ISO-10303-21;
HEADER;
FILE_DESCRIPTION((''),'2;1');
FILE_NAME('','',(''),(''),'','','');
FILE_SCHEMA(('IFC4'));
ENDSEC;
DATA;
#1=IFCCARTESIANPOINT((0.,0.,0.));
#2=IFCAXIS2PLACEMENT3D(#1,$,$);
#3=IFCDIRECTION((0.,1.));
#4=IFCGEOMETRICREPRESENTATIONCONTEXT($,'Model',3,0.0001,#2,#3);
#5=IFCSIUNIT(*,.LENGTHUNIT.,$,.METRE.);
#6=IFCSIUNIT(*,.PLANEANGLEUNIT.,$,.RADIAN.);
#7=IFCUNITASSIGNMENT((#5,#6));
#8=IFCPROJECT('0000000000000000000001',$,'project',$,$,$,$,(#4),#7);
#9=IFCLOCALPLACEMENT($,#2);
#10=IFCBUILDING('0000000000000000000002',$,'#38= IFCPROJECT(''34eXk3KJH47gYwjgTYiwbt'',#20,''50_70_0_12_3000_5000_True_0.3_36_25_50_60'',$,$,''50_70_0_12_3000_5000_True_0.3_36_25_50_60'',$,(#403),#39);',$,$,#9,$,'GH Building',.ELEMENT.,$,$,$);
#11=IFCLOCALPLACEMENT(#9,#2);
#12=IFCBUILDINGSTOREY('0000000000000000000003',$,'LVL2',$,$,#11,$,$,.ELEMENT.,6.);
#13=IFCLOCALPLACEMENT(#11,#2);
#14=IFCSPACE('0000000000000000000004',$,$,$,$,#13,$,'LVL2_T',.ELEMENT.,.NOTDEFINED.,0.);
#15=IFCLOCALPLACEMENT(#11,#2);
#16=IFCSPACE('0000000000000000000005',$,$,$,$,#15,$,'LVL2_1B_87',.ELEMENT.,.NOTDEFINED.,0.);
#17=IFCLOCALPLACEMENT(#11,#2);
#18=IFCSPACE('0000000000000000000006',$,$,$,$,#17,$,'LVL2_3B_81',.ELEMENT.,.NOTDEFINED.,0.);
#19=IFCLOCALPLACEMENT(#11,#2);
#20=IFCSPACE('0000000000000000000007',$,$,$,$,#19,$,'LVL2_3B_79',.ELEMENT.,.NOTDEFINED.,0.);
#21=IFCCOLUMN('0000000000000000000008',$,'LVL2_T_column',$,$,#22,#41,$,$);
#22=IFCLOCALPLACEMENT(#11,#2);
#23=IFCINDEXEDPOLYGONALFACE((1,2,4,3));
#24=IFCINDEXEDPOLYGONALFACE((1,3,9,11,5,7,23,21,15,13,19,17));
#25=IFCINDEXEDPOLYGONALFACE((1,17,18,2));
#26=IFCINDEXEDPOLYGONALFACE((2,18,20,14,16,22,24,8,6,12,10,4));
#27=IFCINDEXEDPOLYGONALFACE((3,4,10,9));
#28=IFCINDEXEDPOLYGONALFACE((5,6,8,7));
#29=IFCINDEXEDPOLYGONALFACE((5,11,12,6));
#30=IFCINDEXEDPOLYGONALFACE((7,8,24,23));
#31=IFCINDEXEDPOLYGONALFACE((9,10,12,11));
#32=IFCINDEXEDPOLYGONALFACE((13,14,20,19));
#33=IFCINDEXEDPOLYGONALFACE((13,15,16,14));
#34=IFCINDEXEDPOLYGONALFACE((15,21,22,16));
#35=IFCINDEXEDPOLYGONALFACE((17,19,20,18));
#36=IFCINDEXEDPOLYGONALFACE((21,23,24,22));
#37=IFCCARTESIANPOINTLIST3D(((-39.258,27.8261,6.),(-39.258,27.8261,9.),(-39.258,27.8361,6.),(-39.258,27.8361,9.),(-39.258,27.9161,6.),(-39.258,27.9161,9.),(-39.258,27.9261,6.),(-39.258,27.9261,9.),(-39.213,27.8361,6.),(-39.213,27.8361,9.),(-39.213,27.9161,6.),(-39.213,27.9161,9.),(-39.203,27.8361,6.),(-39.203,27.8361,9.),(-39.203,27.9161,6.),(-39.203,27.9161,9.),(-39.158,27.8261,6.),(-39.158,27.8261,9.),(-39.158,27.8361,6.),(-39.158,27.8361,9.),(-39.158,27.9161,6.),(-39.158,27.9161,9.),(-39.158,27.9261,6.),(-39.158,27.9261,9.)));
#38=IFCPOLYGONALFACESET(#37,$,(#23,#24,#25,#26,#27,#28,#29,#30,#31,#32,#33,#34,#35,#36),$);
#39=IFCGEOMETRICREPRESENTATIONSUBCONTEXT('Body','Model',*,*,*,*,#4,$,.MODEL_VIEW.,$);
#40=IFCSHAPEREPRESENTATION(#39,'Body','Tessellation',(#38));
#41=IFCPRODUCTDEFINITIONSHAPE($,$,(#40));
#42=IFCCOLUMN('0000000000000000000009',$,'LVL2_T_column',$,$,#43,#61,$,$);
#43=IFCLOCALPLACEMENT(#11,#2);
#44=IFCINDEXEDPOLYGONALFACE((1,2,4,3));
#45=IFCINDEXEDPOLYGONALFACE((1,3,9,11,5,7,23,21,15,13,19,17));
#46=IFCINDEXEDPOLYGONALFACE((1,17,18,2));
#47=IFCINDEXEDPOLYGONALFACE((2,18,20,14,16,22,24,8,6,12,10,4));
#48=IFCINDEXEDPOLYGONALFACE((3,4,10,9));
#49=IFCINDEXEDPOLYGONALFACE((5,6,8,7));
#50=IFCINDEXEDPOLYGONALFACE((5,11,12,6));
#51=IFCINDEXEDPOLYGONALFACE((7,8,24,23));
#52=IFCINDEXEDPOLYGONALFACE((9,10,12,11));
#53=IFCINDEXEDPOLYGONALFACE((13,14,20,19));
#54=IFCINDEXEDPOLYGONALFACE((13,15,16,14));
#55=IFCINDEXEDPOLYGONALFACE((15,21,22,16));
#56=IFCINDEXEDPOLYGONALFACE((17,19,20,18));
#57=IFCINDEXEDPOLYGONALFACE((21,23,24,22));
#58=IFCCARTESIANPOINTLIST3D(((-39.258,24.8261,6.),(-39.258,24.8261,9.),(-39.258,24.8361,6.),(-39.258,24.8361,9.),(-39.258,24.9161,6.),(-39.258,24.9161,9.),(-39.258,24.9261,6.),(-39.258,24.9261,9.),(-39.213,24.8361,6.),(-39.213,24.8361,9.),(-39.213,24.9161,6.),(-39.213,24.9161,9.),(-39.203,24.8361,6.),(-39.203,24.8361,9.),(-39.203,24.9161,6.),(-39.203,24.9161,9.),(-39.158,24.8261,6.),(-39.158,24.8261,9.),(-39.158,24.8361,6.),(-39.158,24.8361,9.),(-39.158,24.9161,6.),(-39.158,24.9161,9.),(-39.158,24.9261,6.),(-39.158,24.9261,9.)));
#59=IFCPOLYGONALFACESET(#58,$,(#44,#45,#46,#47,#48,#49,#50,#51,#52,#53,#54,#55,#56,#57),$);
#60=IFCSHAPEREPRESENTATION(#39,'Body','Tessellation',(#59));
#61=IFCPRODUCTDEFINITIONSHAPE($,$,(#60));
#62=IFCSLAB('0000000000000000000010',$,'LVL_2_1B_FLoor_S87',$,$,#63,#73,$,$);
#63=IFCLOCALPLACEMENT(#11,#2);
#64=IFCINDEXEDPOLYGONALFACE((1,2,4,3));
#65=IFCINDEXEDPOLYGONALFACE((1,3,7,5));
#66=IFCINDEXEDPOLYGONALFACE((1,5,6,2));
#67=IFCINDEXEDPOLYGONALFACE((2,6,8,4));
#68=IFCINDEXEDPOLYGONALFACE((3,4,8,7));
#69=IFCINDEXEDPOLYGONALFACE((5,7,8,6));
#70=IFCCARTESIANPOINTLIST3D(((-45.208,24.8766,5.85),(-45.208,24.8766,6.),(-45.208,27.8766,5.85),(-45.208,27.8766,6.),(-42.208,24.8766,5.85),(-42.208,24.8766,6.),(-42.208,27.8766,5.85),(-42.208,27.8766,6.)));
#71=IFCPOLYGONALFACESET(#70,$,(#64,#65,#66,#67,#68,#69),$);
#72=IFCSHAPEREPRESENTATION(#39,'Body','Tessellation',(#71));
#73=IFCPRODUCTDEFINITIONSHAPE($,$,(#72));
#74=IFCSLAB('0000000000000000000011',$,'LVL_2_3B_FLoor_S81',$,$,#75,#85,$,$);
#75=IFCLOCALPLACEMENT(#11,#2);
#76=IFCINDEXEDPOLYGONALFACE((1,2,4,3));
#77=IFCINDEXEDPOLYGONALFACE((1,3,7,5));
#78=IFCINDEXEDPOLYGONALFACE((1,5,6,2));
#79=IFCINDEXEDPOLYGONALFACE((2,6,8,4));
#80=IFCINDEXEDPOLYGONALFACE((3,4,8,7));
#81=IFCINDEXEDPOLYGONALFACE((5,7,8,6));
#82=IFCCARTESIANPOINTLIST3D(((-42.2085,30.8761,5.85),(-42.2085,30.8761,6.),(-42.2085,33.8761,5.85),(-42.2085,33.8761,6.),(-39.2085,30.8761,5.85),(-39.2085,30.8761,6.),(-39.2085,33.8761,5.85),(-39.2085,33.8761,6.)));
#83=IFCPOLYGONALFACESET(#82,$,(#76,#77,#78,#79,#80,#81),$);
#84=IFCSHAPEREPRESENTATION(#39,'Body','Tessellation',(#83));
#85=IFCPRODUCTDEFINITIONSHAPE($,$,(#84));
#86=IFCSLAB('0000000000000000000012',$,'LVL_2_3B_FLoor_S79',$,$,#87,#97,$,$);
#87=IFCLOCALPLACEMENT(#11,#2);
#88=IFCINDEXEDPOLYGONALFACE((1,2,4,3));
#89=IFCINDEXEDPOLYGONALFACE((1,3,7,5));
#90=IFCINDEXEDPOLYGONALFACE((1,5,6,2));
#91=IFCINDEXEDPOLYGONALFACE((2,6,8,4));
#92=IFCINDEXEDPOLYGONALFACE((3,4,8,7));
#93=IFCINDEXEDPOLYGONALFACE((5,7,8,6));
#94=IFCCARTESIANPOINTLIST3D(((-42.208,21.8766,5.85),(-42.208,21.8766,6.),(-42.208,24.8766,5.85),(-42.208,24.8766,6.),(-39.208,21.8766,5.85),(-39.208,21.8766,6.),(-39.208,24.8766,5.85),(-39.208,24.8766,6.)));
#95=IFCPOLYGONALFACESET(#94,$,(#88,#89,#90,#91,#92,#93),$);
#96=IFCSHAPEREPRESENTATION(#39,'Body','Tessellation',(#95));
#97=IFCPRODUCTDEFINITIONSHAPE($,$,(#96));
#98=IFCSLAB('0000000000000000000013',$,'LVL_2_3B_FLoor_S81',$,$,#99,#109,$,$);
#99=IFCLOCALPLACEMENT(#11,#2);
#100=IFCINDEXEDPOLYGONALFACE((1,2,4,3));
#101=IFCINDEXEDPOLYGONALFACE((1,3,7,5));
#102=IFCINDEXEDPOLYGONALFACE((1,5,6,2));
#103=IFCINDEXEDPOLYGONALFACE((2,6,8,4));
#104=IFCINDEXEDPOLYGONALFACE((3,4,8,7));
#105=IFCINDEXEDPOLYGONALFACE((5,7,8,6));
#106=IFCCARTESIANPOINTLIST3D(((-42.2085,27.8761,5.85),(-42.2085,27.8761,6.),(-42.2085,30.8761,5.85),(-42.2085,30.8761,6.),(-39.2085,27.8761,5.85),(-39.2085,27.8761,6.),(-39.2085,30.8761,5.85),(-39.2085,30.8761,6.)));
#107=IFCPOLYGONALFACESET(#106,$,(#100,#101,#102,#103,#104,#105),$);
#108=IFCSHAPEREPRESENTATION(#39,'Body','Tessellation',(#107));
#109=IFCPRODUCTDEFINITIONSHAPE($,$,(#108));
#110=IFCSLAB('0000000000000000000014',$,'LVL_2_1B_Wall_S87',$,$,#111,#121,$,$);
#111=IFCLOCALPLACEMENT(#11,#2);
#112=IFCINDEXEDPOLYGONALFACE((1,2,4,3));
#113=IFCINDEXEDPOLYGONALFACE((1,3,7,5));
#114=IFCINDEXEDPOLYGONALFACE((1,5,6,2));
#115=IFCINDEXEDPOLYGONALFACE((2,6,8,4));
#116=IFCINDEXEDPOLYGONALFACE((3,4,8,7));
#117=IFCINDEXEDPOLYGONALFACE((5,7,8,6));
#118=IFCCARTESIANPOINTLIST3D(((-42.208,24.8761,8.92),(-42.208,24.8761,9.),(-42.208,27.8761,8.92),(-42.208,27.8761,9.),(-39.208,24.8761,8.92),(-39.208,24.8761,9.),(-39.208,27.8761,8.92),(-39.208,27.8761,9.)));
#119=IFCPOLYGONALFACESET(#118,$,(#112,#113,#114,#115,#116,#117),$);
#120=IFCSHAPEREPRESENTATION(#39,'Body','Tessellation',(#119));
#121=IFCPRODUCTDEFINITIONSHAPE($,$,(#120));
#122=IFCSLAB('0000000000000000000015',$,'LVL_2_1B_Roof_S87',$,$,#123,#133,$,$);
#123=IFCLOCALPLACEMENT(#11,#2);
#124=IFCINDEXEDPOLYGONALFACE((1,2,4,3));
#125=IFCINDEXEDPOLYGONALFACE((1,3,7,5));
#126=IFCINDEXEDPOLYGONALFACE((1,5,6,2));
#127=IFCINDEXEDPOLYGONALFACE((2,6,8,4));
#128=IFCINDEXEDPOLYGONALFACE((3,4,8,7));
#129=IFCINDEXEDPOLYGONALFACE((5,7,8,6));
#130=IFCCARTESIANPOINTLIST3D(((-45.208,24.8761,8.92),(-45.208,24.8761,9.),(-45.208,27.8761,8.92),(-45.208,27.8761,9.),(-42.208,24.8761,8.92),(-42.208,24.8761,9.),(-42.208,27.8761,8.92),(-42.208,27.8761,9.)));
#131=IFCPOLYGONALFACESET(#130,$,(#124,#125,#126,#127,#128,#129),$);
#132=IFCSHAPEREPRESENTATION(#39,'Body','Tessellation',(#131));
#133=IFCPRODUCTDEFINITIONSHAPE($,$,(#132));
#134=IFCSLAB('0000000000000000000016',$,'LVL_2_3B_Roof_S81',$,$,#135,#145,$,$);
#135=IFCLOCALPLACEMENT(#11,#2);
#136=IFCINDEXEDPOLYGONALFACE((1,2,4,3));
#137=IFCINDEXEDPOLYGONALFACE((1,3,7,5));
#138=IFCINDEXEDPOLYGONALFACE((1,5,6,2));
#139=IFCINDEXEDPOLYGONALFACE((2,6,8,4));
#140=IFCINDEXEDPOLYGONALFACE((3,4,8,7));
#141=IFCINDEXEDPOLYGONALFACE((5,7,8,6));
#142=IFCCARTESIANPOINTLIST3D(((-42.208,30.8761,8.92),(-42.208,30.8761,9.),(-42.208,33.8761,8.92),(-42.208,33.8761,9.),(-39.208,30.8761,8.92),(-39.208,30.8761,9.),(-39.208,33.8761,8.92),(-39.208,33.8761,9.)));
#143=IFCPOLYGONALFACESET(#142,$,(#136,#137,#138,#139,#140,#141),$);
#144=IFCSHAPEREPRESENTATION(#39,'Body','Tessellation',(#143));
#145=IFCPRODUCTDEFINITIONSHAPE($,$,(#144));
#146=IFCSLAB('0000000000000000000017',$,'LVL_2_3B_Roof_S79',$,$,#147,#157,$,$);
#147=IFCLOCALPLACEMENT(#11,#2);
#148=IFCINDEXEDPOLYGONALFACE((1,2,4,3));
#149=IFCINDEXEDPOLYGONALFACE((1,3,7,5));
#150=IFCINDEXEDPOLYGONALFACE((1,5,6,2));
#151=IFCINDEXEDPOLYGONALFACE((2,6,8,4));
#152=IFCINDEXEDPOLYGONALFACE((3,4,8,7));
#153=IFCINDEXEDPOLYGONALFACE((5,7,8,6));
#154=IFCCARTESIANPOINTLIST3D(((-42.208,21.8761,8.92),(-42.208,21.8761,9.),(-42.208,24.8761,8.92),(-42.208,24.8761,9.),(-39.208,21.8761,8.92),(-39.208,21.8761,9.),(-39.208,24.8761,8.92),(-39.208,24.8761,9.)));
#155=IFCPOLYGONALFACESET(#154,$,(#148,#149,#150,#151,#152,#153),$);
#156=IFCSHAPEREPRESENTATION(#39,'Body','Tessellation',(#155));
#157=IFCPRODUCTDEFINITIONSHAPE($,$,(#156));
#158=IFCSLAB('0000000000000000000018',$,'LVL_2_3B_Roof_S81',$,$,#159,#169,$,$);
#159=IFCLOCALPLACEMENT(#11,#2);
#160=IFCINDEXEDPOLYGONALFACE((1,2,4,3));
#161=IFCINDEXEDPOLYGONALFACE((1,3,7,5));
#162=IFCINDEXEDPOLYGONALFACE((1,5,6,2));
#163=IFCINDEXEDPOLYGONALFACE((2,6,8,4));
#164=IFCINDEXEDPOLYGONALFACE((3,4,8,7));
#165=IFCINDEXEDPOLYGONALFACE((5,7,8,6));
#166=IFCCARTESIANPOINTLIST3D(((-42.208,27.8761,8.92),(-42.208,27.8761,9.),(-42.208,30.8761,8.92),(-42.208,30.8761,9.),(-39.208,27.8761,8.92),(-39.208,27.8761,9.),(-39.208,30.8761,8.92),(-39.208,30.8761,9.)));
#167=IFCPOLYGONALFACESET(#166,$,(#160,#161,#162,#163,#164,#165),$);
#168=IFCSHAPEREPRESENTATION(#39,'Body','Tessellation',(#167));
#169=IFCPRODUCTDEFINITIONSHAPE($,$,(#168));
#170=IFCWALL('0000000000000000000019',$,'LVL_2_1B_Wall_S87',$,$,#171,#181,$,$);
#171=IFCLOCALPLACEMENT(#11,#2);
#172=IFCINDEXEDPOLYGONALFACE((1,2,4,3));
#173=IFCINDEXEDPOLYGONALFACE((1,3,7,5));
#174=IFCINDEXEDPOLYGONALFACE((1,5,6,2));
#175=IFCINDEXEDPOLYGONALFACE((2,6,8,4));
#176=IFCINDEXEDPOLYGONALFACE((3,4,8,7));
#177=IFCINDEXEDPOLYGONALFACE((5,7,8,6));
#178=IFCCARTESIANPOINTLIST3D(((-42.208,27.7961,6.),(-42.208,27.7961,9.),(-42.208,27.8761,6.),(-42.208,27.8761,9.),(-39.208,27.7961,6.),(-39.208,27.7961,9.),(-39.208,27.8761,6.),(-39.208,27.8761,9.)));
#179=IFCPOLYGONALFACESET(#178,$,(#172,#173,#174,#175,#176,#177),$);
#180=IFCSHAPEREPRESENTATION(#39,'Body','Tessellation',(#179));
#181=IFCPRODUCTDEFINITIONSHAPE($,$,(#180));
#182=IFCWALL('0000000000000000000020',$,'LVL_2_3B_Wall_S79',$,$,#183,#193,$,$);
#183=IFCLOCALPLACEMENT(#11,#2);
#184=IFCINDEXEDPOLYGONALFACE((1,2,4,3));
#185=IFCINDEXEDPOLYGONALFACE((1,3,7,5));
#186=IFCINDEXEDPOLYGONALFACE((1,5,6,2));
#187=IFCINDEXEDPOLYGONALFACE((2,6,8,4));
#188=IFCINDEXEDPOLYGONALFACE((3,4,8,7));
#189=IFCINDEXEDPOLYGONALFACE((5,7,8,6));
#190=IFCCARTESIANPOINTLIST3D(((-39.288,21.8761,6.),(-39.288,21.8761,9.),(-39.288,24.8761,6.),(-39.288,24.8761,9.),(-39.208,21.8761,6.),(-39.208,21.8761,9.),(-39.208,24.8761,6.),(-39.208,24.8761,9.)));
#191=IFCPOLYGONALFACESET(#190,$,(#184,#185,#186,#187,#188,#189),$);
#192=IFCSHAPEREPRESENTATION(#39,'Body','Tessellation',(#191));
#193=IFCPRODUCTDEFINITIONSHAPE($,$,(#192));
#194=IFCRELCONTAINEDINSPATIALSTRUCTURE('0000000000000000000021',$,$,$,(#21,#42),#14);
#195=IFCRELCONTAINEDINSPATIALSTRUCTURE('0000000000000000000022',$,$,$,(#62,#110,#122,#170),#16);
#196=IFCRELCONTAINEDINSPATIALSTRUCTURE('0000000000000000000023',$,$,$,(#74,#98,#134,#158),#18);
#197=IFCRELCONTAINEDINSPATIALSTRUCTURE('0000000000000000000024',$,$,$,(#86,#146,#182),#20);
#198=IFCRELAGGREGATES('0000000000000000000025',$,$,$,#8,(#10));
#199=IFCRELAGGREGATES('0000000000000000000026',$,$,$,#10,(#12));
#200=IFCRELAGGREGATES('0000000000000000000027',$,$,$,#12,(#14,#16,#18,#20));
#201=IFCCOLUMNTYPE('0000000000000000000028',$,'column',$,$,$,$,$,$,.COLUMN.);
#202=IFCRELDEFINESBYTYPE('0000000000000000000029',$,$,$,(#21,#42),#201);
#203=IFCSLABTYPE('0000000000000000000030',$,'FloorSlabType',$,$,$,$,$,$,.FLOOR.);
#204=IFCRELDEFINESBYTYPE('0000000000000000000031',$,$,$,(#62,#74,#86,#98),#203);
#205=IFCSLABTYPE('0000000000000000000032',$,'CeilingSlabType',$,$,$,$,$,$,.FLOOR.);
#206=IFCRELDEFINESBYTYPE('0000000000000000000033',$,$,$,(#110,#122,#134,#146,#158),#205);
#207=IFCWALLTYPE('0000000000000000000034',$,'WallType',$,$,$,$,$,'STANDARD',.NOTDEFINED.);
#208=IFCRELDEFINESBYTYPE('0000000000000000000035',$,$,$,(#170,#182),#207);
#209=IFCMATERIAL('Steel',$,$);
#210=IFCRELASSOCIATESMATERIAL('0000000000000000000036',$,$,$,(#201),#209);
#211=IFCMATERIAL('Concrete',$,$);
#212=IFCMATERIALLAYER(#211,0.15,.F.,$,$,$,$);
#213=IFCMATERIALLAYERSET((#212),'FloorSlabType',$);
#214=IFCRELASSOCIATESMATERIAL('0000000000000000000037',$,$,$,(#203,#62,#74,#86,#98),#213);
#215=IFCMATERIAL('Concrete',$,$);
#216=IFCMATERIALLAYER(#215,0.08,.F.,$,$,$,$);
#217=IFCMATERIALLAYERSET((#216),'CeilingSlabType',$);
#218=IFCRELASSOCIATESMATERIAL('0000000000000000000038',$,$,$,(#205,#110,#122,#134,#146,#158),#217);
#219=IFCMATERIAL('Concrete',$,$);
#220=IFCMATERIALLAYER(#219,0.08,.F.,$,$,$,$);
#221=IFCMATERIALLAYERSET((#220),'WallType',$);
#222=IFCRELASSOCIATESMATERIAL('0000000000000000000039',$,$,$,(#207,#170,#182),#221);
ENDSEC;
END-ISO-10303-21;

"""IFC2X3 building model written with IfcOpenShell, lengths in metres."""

from ifc_helpers import new_model, si_unit, direction, frame, frame_2d, origin, origin_2d, place, context, subcontext, project, spatial, rectangle, i_section, extrude, material, layer, layer_set, layer_usage, type_object, element, save


model = new_model("IFC2X3")

# Units and contexts
model_context = context("Model", 3, precision=0.0001, world=origin(), true_north=direction((0.0, 1.0)))
body_context = subcontext(model_context, "Body", "Model", "MODEL_VIEW")
ifc_project = project(units=[si_unit("LENGTHUNIT", "METRE"), si_unit("PLANEANGLEUNIT", "RADIAN")], contexts=[model_context])

# Building, storey, space
building_placement = place(None, origin())
building = spatial("IfcBuilding", under=ifc_project, at=building_placement, Name="#38= IFCPROJECT('34eXk3KJH47gYwjgTYiwbt',#20,'50_70_0_12_3000_5000_True_0.3_36_25_50_60',$,$,'50_70_0_12_3000_5000_True_0.3_36_25_50_60',$,(#403),#39);", LongName="GH Building", CompositionType="ELEMENT")
storey_placement = place(building_placement, origin())
storey = spatial("IfcBuildingStorey", under=building, at=storey_placement, Name="LVL2", CompositionType="ELEMENT", Elevation=6.0)
space_1_placement = place(storey_placement, origin())
space_1 = spatial("IfcSpace", under=storey, at=space_1_placement, LongName="LVL2_T", CompositionType="ELEMENT", InteriorOrExteriorSpace="NOTDEFINED", ElevationWithFlooring=0.0)

# Columns
ifc_material_1 = material(Name="Steel")
column_type = type_object("IfcColumnType", Name="column", PredefinedType="COLUMN", material=ifc_material_1)
for number, where, name in (
    (1, (-39.208, 27.8761, 6.0), "LVL2_T_column"),
    (2, (-39.208, 24.8761, 6.0), "LVL2_T_column"),
):
    element("IfcColumn", number, at=place(space_1_placement, frame(where)), inside=space_1, type_object=column_type, Name=name, context=body_context, shape_type="SweptSolid", body=[
        extrude(i_section(OverallWidth=0.1, OverallDepth=0.1, WebThickness=0.01, FlangeThickness=0.01, at=origin_2d()), origin(), (0.0, 0.0, 1.0), 3.0),
    ])

# Shared definitions
space_2_placement = place(storey_placement, origin())
space_2 = spatial("IfcSpace", under=storey, at=space_2_placement, LongName="LVL2_1B_87", CompositionType="ELEMENT", InteriorOrExteriorSpace="NOTDEFINED", ElevationWithFlooring=0.0)

# Slab
ifc_material_2 = material(Name="Concrete")
ifc_layer_1 = layer(ifc_material_2, 0.15, ventilated=False)
ifc_layer_set_1 = layer_set([ifc_layer_1], Name="FloorSlabType")
ifc_layer_usage_1 = layer_usage(ifc_layer_set_1, "AXIS3", "NEGATIVE", -0.15)
slab_type_1 = type_object("IfcSlabType", Name="FloorSlabType", PredefinedType="FLOOR", material=ifc_layer_set_1)
slab_1_placement = place(space_2_placement, frame((-42.208, 27.8766, 5.85), z_axis=(0.0, 0.0, 1.0), x_axis=(-1.0, 0.0, 0.0)))
element("IfcSlab", 3, at=slab_1_placement, inside=space_2, type_object=slab_type_1, material=ifc_layer_usage_1, Name="LVL_2_1B_FLoor_S87", context=body_context, shape_type="SweptSolid", body=[
    extrude(rectangle(XDim=3.0, YDim=3.0, at=frame_2d((1.5, 1.5))), origin(), (0.0, 0.0, 1.0), 0.15),
])

# Shared definitions
space_3_placement = place(storey_placement, origin())
space_3 = spatial("IfcSpace", under=storey, at=space_3_placement, LongName="LVL2_3B_81", CompositionType="ELEMENT", InteriorOrExteriorSpace="NOTDEFINED", ElevationWithFlooring=0.0)

# Slab
ifc_layer_usage_2 = layer_usage(ifc_layer_set_1, "AXIS3", "NEGATIVE", -0.15)
slab_2_placement = place(space_3_placement, frame((-42.2085, 33.8761, 5.85), z_axis=(0.0, 0.0, 1.0), x_axis=(0.0, -1.0, 0.0)))
element("IfcSlab", 4, at=slab_2_placement, inside=space_3, type_object=slab_type_1, material=ifc_layer_usage_2, Name="LVL_2_3B_FLoor_S81", context=body_context, shape_type="SweptSolid", body=[
    extrude(rectangle(XDim=3.0, YDim=3.0, at=frame_2d((1.5, 1.5))), origin(), (0.0, 0.0, 1.0), 0.15),
])

# Shared definitions
space_4_placement = place(storey_placement, origin())
space_4 = spatial("IfcSpace", under=storey, at=space_4_placement, LongName="LVL2_3B_79", CompositionType="ELEMENT", InteriorOrExteriorSpace="NOTDEFINED", ElevationWithFlooring=0.0)

# Slabs
ifc_layer_usage_3 = layer_usage(ifc_layer_set_1, "AXIS3", "NEGATIVE", -0.15)
slab_3_placement = place(space_4_placement, frame((-39.208, 24.8766, 5.85), z_axis=(0.0, 0.0, 1.0), x_axis=(-1.0, 0.0, 0.0)))
element("IfcSlab", 5, at=slab_3_placement, inside=space_4, type_object=slab_type_1, material=ifc_layer_usage_3, Name="LVL_2_3B_FLoor_S79", context=body_context, shape_type="SweptSolid", body=[
    extrude(rectangle(XDim=3.0, YDim=3.0, at=frame_2d((1.5, 1.5))), origin(), (0.0, 0.0, 1.0), 0.15),
])
ifc_layer_usage_4 = layer_usage(ifc_layer_set_1, "AXIS3", "NEGATIVE", -0.15)
slab_4_placement = place(space_3_placement, frame((-42.2085, 30.8761, 5.85), z_axis=(0.0, 0.0, 1.0), x_axis=(0.0, -1.0, 0.0)))
element("IfcSlab", 6, at=slab_4_placement, inside=space_3, type_object=slab_type_1, material=ifc_layer_usage_4, Name="LVL_2_3B_FLoor_S81", context=body_context, shape_type="SweptSolid", body=[
    extrude(rectangle(XDim=3.0, YDim=3.0, at=frame_2d((1.5, 1.5))), origin(), (0.0, 0.0, 1.0), 0.15),
])
ifc_material_3 = material(Name="Concrete")
ifc_layer_2 = layer(ifc_material_3, 0.08, ventilated=False)
ifc_layer_set_2 = layer_set([ifc_layer_2], Name="CeilingSlabType")
ifc_layer_usage_5 = layer_usage(ifc_layer_set_2, "AXIS3", "NEGATIVE", -0.08)
slab_type_2 = type_object("IfcSlabType", Name="CeilingSlabType", PredefinedType="FLOOR", material=ifc_layer_set_2)
slab_5_placement = place(space_2_placement, frame((-39.208, 27.8761, 8.92), z_axis=(0.0, 0.0, 1.0), x_axis=(-1.0, 0.0, 0.0)))
element("IfcSlab", 7, at=slab_5_placement, inside=space_2, type_object=slab_type_2, material=ifc_layer_usage_5, Name="LVL_2_1B_Wall_S87", context=body_context, shape_type="SweptSolid", body=[
    extrude(rectangle(XDim=3.0, YDim=3.0, at=frame_2d((1.5, 1.5))), origin(), (0.0, 0.0, 1.0), 0.08),
])
ifc_layer_usage_6 = layer_usage(ifc_layer_set_2, "AXIS3", "NEGATIVE", -0.08)
slab_6_placement = place(space_2_placement, frame((-42.208, 27.8761, 8.92), z_axis=(0.0, 0.0, 1.0), x_axis=(-1.0, 0.0, 0.0)))
element("IfcSlab", 8, at=slab_6_placement, inside=space_2, type_object=slab_type_2, material=ifc_layer_usage_6, Name="LVL_2_1B_Roof_S87", context=body_context, shape_type="SweptSolid", body=[
    extrude(rectangle(XDim=3.0, YDim=3.0, at=frame_2d((1.5, 1.5))), origin(), (0.0, 0.0, 1.0), 0.08),
])
ifc_layer_usage_7 = layer_usage(ifc_layer_set_2, "AXIS3", "NEGATIVE", -0.08)
slab_7_placement = place(space_3_placement, frame((-42.208, 33.8761, 8.92), z_axis=(0.0, 0.0, 1.0), x_axis=(0.0, -1.0, 0.0)))
element("IfcSlab", 9, at=slab_7_placement, inside=space_3, type_object=slab_type_2, material=ifc_layer_usage_7, Name="LVL_2_3B_Roof_S81", context=body_context, shape_type="SweptSolid", body=[
    extrude(rectangle(XDim=3.0, YDim=3.0, at=frame_2d((1.5, 1.5))), origin(), (0.0, 0.0, 1.0), 0.08),
])
ifc_layer_usage_8 = layer_usage(ifc_layer_set_2, "AXIS3", "NEGATIVE", -0.08)
slab_8_placement = place(space_4_placement, frame((-39.208, 24.8761, 8.92), z_axis=(0.0, 0.0, 1.0), x_axis=(-1.0, 0.0, 0.0)))
element("IfcSlab", 10, at=slab_8_placement, inside=space_4, type_object=slab_type_2, material=ifc_layer_usage_8, Name="LVL_2_3B_Roof_S79", context=body_context, shape_type="SweptSolid", body=[
    extrude(rectangle(XDim=3.0, YDim=3.0, at=frame_2d((1.5, 1.5))), origin(), (0.0, 0.0, 1.0), 0.08),
])
ifc_layer_usage_9 = layer_usage(ifc_layer_set_2, "AXIS3", "NEGATIVE", -0.08)
slab_9_placement = place(space_3_placement, frame((-42.208, 27.8761, 8.92), z_axis=(0.0, 0.0, 1.0), x_axis=(0.0, 1.0, 0.0)))
element("IfcSlab", 11, at=slab_9_placement, inside=space_3, type_object=slab_type_2, material=ifc_layer_usage_9, Name="LVL_2_3B_Roof_S81", context=body_context, shape_type="SweptSolid", body=[
    extrude(rectangle(XDim=3.0, YDim=3.0, at=frame_2d((1.5, -1.5))), origin(), (0.0, 0.0, 1.0), 0.08),
])

# Shared definitions
ifc_material_4 = material(Name="Concrete")
ifc_layer_3 = layer(ifc_material_4, 0.08, ventilated=False)
ifc_layer_set_3 = layer_set([ifc_layer_3], Name="WallType")
wall_type = type_object("IfcWallType", Name="WallType", ElementType="STANDARD", PredefinedType="NOTDEFINED", material=ifc_layer_set_3)

# Wall
ifc_layer_usage_10 = layer_usage(ifc_layer_set_3, "AXIS2", "NEGATIVE", 0.0)
wall_1_placement = place(space_2_placement, frame((-42.208, 27.8761, 6.0)))
element("IfcWall", 12, at=wall_1_placement, inside=space_2, type_object=wall_type, material=ifc_layer_usage_10, Name="LVL_2_1B_Wall_S87", context=body_context, shape_type="SweptSolid", body=[
    extrude(rectangle(XDim=3.0, YDim=0.08, at=frame_2d((1.5, -0.04))), origin(), (0.0, 0.0, 1.0), 3.0),
])

# Wall
ifc_layer_usage_11 = layer_usage(ifc_layer_set_3, "AXIS2", "NEGATIVE", 0.0)
wall_2_placement = place(space_4_placement, frame((-39.208, 24.8761, 6.0), z_axis=(0.0, 0.0, 1.0), x_axis=(0.0, -1.0, 0.0)))
element("IfcWall", 13, at=wall_2_placement, inside=space_4, type_object=wall_type, material=ifc_layer_usage_11, Name="LVL_2_3B_Wall_S79", context=body_context, shape_type="SweptSolid", body=[
    extrude(rectangle(XDim=3.0, YDim=0.08, at=frame_2d((1.5, -0.04))), origin(), (0.0, 0.0, 1.0), 3.0),
])

save(model, "model.ifc")
